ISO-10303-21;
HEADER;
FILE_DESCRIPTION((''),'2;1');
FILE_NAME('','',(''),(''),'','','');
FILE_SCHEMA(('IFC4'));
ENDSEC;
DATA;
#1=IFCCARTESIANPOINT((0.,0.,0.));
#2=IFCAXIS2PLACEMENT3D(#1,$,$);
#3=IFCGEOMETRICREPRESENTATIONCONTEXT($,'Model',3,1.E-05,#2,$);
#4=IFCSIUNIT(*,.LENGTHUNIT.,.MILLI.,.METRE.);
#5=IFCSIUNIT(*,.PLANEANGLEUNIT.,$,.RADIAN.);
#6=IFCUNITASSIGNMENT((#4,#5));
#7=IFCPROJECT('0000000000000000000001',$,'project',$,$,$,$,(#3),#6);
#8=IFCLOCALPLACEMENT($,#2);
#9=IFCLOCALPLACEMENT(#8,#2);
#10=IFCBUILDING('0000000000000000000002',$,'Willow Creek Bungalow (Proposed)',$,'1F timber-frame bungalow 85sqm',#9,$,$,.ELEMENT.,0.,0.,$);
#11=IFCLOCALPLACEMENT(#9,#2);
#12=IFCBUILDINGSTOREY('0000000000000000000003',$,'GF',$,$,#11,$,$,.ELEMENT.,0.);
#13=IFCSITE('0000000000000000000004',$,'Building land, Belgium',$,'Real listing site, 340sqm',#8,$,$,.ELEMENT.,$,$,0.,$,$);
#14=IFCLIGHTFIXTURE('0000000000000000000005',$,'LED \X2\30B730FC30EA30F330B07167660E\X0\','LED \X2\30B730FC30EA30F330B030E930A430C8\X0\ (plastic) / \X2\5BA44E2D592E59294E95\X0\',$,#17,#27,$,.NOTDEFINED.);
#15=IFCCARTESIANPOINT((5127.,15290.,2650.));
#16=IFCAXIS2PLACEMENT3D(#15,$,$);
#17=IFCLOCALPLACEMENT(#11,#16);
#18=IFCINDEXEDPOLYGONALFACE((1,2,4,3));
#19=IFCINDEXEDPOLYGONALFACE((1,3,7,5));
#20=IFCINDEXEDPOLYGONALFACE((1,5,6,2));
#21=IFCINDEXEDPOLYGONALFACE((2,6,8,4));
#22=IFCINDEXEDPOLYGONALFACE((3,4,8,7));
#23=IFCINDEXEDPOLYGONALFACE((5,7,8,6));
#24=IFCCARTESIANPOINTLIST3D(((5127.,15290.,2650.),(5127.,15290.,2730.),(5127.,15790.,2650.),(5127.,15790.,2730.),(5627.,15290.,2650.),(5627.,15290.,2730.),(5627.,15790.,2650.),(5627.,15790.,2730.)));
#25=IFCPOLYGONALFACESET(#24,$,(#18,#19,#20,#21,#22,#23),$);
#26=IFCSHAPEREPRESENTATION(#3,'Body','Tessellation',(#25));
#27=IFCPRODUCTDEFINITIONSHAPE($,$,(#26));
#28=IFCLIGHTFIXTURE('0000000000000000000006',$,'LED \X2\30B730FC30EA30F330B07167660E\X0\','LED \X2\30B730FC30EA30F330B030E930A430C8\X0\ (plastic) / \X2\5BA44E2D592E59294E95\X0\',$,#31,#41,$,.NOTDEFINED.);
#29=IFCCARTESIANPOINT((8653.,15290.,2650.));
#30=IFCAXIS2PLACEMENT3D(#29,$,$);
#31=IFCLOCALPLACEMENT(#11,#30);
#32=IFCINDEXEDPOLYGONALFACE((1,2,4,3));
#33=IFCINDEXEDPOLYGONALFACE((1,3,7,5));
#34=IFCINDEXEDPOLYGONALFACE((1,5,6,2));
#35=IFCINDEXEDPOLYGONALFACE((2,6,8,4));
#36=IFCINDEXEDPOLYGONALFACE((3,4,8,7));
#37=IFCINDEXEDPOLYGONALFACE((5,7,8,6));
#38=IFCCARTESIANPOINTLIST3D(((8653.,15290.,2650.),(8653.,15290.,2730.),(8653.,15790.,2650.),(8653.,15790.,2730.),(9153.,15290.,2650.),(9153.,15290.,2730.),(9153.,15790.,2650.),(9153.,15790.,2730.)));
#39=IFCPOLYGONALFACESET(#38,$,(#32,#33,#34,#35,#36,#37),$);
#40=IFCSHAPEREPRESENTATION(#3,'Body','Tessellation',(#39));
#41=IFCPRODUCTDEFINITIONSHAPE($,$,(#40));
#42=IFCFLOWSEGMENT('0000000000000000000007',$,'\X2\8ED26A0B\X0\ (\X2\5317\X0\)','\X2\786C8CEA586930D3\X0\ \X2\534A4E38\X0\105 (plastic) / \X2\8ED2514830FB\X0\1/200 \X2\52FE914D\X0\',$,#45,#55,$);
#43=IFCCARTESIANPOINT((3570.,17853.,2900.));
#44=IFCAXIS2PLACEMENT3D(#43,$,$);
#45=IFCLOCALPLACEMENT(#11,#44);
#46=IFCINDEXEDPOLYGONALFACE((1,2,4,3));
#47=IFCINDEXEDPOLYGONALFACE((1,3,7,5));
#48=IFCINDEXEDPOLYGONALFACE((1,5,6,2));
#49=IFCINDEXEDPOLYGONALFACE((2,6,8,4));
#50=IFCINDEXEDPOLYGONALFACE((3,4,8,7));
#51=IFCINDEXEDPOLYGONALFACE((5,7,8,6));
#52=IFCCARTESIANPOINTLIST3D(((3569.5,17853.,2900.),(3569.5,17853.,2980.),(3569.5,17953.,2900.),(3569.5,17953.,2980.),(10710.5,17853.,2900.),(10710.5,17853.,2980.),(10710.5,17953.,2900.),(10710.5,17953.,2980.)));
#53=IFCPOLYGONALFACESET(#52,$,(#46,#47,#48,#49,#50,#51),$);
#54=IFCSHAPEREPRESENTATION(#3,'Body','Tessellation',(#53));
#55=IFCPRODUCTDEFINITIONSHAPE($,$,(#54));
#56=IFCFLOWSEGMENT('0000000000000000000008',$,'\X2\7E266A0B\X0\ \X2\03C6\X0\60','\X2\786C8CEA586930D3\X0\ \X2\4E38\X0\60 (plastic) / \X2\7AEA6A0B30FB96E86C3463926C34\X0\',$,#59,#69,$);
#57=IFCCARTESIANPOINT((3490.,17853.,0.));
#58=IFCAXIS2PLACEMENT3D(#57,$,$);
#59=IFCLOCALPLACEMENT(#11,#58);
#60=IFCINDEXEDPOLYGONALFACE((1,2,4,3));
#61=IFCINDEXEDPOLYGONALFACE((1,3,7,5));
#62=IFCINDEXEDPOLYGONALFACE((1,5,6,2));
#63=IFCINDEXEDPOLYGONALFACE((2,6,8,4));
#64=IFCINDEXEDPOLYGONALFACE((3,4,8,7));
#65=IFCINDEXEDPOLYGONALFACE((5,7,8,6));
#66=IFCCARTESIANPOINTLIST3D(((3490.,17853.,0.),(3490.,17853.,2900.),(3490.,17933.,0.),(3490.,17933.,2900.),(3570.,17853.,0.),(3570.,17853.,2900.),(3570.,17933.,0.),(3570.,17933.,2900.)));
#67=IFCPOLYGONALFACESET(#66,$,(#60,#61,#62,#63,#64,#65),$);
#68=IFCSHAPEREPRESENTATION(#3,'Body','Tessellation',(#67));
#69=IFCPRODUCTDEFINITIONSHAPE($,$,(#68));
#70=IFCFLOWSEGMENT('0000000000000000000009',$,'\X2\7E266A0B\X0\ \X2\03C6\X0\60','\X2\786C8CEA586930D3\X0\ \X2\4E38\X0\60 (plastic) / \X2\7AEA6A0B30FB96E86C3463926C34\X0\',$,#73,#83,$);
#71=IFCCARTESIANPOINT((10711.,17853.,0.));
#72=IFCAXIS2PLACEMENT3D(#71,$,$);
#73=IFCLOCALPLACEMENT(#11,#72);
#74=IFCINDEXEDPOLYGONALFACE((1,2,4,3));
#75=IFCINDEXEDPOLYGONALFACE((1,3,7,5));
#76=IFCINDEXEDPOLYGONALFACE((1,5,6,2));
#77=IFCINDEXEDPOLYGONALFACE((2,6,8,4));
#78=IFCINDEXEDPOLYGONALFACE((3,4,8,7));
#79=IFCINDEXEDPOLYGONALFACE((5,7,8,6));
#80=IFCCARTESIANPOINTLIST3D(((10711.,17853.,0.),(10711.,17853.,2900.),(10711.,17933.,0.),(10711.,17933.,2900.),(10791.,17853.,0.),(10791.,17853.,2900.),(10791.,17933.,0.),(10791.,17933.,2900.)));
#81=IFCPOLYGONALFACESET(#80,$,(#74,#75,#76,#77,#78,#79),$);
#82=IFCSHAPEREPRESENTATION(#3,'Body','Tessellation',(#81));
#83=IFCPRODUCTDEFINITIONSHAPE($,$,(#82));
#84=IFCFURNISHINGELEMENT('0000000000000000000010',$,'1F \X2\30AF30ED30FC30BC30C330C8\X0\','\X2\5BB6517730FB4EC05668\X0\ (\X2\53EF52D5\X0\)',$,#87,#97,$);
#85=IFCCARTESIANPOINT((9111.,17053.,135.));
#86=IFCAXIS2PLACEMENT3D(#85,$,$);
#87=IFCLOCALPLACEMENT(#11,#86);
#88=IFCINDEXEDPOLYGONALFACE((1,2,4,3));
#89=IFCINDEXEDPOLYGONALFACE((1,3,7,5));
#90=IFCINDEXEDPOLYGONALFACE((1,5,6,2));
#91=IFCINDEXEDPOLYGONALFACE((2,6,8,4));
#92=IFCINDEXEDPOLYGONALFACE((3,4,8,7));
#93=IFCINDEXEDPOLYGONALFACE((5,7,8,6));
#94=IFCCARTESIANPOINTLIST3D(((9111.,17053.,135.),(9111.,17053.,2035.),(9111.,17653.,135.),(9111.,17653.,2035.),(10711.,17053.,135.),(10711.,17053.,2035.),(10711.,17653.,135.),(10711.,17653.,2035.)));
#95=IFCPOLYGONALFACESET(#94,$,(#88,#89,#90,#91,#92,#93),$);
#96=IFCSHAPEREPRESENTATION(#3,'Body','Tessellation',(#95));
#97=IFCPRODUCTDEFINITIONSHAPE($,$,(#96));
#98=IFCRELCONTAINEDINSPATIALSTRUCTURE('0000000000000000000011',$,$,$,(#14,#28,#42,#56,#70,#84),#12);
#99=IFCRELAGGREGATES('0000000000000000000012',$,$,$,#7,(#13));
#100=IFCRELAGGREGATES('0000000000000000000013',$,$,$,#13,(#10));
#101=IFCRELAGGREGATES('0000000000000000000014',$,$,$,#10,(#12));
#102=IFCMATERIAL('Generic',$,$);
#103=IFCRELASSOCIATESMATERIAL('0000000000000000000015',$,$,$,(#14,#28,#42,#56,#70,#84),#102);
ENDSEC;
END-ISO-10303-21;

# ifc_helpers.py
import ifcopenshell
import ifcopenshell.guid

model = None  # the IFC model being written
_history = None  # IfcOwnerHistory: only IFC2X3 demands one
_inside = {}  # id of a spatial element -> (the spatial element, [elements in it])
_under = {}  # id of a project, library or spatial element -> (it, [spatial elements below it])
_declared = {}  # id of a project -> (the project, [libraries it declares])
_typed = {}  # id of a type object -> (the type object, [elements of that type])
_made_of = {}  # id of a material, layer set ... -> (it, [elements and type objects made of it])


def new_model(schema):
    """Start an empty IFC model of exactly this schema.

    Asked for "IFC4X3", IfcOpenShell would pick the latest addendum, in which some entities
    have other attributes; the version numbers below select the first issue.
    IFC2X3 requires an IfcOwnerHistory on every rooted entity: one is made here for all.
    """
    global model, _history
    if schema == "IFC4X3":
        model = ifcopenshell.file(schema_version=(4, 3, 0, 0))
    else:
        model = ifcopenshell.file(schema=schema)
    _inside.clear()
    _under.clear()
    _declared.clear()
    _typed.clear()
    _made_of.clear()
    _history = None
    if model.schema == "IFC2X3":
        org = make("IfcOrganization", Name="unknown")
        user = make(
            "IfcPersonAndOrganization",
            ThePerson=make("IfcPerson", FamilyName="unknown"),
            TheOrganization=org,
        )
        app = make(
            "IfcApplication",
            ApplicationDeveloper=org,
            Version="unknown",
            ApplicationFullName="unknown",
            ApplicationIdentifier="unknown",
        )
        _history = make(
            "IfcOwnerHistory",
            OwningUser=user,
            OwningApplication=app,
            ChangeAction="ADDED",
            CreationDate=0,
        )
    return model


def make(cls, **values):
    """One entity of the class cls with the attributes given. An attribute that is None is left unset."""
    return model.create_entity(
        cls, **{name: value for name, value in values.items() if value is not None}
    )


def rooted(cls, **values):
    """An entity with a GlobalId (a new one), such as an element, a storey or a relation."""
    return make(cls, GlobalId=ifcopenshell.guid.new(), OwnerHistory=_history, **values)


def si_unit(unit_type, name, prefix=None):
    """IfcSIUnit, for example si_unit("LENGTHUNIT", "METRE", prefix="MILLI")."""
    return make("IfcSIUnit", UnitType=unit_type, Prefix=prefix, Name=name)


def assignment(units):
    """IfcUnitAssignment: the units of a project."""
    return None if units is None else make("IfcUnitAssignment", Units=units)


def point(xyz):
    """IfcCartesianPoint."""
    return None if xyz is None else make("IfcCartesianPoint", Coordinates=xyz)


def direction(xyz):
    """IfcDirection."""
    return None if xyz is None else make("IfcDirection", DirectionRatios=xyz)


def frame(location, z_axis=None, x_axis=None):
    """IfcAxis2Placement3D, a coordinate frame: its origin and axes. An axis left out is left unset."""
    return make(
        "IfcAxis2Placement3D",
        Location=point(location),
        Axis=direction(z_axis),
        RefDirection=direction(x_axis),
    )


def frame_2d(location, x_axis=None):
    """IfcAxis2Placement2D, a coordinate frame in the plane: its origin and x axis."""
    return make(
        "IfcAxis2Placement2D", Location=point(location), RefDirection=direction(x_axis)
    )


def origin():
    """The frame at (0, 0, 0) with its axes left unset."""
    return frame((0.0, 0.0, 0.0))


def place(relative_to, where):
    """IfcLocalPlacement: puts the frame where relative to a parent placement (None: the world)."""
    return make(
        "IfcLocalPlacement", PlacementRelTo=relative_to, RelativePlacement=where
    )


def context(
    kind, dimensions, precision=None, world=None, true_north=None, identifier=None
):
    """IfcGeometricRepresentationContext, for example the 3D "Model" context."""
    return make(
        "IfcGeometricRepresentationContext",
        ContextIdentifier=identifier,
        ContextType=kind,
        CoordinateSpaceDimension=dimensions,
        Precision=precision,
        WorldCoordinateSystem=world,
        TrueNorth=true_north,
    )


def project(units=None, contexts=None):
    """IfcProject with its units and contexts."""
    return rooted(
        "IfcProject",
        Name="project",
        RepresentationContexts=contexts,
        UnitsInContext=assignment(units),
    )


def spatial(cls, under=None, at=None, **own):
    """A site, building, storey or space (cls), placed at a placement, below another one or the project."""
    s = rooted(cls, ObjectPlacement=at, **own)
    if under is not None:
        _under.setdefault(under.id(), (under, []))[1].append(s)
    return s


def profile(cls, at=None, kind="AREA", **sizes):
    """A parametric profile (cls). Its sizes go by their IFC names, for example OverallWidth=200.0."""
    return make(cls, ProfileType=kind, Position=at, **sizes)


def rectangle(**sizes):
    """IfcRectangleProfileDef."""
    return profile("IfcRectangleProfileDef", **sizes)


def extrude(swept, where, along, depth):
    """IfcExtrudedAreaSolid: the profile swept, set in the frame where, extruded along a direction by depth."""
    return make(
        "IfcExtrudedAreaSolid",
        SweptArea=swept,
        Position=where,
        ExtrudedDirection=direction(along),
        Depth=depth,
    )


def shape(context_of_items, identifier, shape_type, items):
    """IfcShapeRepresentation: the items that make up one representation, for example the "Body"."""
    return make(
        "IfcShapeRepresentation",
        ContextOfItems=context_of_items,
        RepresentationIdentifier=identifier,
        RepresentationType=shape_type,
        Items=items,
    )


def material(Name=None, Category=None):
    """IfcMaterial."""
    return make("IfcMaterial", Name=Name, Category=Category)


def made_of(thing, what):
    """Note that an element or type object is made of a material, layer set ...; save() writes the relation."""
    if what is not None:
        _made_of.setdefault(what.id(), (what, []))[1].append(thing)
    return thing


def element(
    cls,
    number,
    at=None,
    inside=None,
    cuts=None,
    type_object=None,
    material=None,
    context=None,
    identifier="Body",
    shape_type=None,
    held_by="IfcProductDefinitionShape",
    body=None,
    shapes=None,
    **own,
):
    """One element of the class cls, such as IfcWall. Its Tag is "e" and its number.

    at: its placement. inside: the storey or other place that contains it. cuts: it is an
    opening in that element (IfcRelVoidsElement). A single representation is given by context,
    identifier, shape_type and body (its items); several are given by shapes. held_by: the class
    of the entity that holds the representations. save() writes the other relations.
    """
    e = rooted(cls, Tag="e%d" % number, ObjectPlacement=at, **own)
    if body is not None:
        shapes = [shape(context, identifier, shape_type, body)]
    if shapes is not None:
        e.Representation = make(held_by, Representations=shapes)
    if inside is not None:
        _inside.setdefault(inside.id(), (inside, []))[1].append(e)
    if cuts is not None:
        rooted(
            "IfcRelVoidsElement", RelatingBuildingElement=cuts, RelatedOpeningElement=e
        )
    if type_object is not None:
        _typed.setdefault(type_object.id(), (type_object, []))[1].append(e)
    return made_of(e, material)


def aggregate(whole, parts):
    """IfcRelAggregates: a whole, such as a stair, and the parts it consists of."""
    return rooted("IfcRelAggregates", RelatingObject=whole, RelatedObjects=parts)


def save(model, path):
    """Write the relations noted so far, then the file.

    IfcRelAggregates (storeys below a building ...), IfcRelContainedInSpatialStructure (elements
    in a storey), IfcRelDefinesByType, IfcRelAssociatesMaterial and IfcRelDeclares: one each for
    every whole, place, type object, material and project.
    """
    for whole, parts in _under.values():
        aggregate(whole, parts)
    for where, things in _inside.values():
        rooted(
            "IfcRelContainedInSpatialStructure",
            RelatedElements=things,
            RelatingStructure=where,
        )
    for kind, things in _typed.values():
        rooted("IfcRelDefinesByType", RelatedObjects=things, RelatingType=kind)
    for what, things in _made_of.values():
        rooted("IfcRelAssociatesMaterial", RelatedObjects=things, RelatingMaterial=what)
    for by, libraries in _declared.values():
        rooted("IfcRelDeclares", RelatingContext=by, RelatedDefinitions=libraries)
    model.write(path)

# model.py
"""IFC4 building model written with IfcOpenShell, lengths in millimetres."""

from ifc_helpers import new_model, si_unit, frame, frame_2d, origin, place, context, project, spatial, rectangle, extrude, material, element, save


model = new_model("IFC4")

# Units and contexts
model_context = context("Model", 3, precision=1e-05, world=origin())
ifc_project = project(units=[si_unit("LENGTHUNIT", "METRE", prefix="MILLI"), si_unit("PLANEANGLEUNIT", "RADIAN")], contexts=[model_context])

# Site, building, storey
site_placement = place(None, origin())
site = spatial("IfcSite", under=ifc_project, at=site_placement, Name="Building land, Belgium", ObjectType="Real listing site, 340sqm", CompositionType="ELEMENT", RefElevation=0.0)
building_placement = place(site_placement, origin())
building = spatial("IfcBuilding", under=site, at=building_placement, Name="Willow Creek Bungalow (Proposed)", ObjectType="1F timber-frame bungalow 85sqm", CompositionType="ELEMENT", ElevationOfRefHeight=0.0, ElevationOfTerrain=0.0)
storey_placement = place(building_placement, origin())
storey = spatial("IfcBuildingStorey", under=building, at=storey_placement, Name="GF", CompositionType="ELEMENT", Elevation=0.0)

# Shared definitions
ifc_material_1 = material(Name="Generic")

# Light fixtures
light_fixture_1_placement = place(storey_placement, frame((5127.0, 15290.0, 2650.0)))
element("IfcLightFixture", 1, at=light_fixture_1_placement, inside=storey, material=ifc_material_1, Name="LED シーリング照明", Description="LED シーリングライト (plastic) / 室中央天井", PredefinedType="NOTDEFINED", context=model_context, shape_type="SweptSolid", body=[
    extrude(rectangle(XDim=500.0, YDim=500.0, at=frame_2d((250.0, 250.0))), frame((5127.0, 15290.0, 2650.0)), (0.0, 0.0, 1.0), 80.0),
])
light_fixture_2_placement = place(storey_placement, frame((8653.0, 15290.0, 2650.0)))
element("IfcLightFixture", 2, at=light_fixture_2_placement, inside=storey, material=ifc_material_1, Name="LED シーリング照明", Description="LED シーリングライト (plastic) / 室中央天井", PredefinedType="NOTDEFINED", context=model_context, shape_type="SweptSolid", body=[
    extrude(rectangle(XDim=500.0, YDim=500.0, at=frame_2d((250.0, 250.0))), frame((8653.0, 15290.0, 2650.0)), (0.0, 0.0, 1.0), 80.0),
])

# Flow segments
flow_segment_1_placement = place(storey_placement, frame((3570.0, 17853.0, 2900.0)))
element("IfcFlowSegment", 3, at=flow_segment_1_placement, inside=storey, material=ifc_material_1, Name="軒樋 (北)", Description="硬質塩ビ 半丸105 (plastic) / 軒先・1/200 勾配", context=model_context, shape_type="SweptSolid", body=[
    extrude(rectangle(XDim=7141.0, YDim=100.0, at=frame_2d((3570.0, 50.0))), frame((3570.0, 17853.0, 2900.0)), (0.0, 0.0, 1.0), 80.0),
])
flow_segment_2_placement = place(storey_placement, frame((3490.0, 17853.0, 0.0)))
element("IfcFlowSegment", 4, at=flow_segment_2_placement, inside=storey, material=ifc_material_1, Name="縦樋 φ60", Description="硬質塩ビ 丸60 (plastic) / 竪樋・雨水排水", context=model_context, shape_type="SweptSolid", body=[
    extrude(rectangle(XDim=80.0, YDim=80.0, at=frame_2d((40.0, 40.0))), frame((3490.0, 17853.0, 0.0)), (0.0, 0.0, 1.0), 2900.0),
])
flow_segment_3_placement = place(storey_placement, frame((10711.0, 17853.0, 0.0)))
element("IfcFlowSegment", 5, at=flow_segment_3_placement, inside=storey, material=ifc_material_1, Name="縦樋 φ60", Description="硬質塩ビ 丸60 (plastic) / 竪樋・雨水排水", context=model_context, shape_type="SweptSolid", body=[
    extrude(rectangle(XDim=80.0, YDim=80.0, at=frame_2d((40.0, 40.0))), frame((10711.0, 17853.0, 0.0)), (0.0, 0.0, 1.0), 2900.0),
])

# Furnishing element
furnishing_placement = place(storey_placement, frame((9111.0, 17053.0, 135.0)))
element("IfcFurnishingElement", 6, at=furnishing_placement, inside=storey, material=ifc_material_1, Name="1F クローゼット", Description="家具・什器 (可動)", context=model_context, shape_type="SweptSolid", body=[
    extrude(rectangle(XDim=1600.0, YDim=600.0, at=frame_2d((800.0, 300.0))), frame((9111.0, 17053.0, 135.0)), (0.0, 0.0, 1.0), 1900.0),
])

save(model, "model.ifc")
